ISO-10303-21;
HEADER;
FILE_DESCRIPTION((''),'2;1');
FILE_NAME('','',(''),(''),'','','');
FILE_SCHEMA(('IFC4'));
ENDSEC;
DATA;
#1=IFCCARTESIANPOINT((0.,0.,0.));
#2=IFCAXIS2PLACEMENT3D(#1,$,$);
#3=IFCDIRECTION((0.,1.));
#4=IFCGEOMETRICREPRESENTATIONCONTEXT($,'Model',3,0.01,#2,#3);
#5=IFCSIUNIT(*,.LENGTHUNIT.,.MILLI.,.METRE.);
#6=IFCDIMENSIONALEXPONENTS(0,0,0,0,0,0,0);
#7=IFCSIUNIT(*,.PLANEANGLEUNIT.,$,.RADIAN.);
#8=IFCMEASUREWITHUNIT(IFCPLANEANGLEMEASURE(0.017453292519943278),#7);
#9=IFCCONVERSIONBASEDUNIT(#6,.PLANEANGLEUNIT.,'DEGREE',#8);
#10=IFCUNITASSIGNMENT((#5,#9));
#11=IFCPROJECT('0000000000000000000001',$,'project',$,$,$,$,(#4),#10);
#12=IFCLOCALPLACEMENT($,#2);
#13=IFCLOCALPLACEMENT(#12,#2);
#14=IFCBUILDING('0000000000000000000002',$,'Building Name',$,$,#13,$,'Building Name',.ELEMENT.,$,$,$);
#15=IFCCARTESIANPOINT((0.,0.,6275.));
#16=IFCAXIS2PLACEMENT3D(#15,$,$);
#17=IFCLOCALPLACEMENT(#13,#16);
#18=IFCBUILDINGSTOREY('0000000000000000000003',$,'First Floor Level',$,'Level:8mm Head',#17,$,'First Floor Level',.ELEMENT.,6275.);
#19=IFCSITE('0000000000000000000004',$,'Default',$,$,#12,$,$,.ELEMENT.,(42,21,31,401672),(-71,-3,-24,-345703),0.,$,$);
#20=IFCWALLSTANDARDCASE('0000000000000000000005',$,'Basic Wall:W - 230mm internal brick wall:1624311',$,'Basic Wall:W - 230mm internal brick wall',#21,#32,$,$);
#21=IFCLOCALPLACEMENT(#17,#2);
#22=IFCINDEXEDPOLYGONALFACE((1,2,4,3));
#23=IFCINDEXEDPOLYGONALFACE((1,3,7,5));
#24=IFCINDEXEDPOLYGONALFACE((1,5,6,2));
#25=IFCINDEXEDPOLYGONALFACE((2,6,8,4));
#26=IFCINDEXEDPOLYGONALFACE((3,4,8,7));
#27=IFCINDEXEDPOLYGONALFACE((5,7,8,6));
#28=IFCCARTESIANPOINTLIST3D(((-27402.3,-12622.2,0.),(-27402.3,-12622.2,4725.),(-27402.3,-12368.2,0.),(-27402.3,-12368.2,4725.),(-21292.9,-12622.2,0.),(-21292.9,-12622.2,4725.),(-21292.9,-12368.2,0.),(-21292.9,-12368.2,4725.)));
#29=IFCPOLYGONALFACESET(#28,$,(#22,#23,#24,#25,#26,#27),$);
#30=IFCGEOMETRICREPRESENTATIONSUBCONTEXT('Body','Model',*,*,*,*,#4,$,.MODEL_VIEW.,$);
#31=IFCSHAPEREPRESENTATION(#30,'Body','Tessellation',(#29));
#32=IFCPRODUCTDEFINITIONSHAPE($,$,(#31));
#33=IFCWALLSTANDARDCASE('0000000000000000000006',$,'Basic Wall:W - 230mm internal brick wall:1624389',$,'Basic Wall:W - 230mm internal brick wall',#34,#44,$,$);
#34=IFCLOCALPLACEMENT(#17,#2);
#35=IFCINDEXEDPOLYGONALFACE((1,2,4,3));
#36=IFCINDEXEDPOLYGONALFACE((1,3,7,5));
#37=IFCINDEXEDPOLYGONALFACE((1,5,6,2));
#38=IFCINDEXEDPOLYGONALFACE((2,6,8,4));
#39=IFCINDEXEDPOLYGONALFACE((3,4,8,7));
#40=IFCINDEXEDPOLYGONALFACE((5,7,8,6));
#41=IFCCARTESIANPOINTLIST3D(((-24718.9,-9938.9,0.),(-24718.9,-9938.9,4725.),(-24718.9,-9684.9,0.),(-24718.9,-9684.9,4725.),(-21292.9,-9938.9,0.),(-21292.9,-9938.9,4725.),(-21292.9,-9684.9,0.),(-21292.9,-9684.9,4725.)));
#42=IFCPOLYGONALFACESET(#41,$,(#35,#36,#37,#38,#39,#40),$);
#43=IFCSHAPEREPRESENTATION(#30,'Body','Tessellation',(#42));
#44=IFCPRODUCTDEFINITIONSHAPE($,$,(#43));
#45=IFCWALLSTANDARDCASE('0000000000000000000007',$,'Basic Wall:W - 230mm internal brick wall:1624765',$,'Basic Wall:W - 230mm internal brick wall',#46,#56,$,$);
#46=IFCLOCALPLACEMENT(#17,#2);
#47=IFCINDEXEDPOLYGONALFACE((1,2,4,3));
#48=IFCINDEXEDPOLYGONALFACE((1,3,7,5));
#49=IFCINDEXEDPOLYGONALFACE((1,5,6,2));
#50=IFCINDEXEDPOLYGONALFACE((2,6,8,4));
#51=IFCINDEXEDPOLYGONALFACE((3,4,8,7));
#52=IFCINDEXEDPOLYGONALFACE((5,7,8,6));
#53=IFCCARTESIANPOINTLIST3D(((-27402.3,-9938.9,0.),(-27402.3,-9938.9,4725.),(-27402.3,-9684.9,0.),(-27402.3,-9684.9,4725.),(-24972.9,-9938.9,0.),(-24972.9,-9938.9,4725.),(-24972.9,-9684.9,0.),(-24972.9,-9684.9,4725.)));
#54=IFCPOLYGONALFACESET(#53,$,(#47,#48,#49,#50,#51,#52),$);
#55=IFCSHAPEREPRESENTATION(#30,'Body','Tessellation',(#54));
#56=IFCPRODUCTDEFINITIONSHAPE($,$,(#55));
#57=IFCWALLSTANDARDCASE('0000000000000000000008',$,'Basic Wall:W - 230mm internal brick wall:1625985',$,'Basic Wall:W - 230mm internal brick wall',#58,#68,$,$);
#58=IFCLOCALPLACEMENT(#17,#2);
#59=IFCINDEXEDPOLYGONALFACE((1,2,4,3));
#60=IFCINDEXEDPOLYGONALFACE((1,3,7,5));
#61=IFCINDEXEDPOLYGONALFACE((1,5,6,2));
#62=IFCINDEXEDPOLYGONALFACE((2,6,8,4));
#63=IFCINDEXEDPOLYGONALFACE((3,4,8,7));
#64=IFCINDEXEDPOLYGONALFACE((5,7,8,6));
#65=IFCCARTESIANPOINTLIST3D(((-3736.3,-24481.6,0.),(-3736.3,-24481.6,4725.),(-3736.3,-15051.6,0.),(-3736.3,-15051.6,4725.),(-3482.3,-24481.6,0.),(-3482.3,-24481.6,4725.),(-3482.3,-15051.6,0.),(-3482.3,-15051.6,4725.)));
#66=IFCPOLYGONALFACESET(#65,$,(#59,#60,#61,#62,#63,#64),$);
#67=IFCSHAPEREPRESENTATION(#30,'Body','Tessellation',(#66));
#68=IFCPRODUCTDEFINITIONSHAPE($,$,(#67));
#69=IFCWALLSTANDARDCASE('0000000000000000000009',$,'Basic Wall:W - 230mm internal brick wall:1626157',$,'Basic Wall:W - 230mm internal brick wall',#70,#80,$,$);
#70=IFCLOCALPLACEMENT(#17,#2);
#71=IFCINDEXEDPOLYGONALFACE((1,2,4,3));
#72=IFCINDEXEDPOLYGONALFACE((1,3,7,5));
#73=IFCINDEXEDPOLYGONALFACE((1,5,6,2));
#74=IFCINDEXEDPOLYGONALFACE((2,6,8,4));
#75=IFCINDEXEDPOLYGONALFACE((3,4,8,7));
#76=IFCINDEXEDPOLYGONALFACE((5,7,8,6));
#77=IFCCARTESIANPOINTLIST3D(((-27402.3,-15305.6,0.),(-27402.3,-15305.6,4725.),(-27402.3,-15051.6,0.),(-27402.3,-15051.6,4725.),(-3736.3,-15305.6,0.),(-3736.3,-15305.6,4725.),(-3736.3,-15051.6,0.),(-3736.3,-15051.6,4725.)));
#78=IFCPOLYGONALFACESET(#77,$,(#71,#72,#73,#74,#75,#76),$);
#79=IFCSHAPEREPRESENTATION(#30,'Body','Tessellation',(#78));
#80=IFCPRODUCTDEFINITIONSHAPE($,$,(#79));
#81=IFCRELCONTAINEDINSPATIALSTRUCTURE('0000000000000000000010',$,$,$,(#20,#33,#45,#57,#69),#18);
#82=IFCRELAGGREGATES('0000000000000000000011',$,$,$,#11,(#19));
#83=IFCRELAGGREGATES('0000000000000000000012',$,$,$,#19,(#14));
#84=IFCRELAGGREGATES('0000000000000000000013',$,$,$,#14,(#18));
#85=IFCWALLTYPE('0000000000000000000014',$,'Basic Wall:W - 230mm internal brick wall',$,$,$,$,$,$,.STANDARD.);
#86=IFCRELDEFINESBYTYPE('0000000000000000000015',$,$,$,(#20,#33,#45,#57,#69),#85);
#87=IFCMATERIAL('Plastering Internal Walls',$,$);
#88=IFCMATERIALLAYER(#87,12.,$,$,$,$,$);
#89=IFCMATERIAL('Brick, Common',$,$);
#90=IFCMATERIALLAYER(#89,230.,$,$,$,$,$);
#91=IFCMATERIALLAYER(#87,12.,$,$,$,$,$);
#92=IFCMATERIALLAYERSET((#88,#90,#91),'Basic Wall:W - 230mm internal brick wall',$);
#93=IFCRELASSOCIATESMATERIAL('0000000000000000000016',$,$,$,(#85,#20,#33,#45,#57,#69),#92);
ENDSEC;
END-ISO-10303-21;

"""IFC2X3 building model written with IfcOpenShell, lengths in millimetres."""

from ifc_helpers import new_model, entity, si_unit, converted_unit, direction, frame, frame_2d, origin, place, context, subcontext, project, spatial, rectangle, extrude, material, layer, layer_set, layer_usage, type_object, element, save


model = new_model("IFC2X3")

# Units and contexts
model_context = context("Model", 3, precision=0.01, world=origin(), true_north=direction((0.0, 1.0)))
body_context = subcontext(model_context, "Body", "Model", "MODEL_VIEW")
ifc_project = project(units=[si_unit("LENGTHUNIT", "METRE", prefix="MILLI"), converted_unit("PLANEANGLEUNIT", "DEGREE", entity("IfcPlaneAngleMeasure", 0.017453292519943278), si_unit("PLANEANGLEUNIT", "RADIAN"), dimensions=[0, 0, 0, 0, 0, 0, 0])], contexts=[model_context])

# Site, building, storey
site_placement = place(None, origin())
site = spatial("IfcSite", under=ifc_project, at=site_placement, Name="Default", CompositionType="ELEMENT", RefLatitude=(42, 21, 31, 401672), RefLongitude=(-71, -3, -24, -345703), RefElevation=0.0)
building_placement = place(site_placement, origin())
building = spatial("IfcBuilding", under=site, at=building_placement, Name="Building Name", LongName="Building Name", CompositionType="ELEMENT")
storey_placement = place(building_placement, frame((0.0, 0.0, 6275.0)))
storey = spatial("IfcBuildingStorey", under=building, at=storey_placement, Name="First Floor Level", ObjectType="Level:8mm Head", LongName="First Floor Level", CompositionType="ELEMENT", Elevation=6275.0)

# Walls
ifc_material_1 = material(Name="Brick, Common")
ifc_material_2 = material(Name="Plastering Internal Walls")
ifc_layer_1 = layer(ifc_material_2, 12.0)
ifc_layer_2 = layer(ifc_material_1, 230.0)
ifc_layer_3 = layer(ifc_material_2, 12.0)
ifc_layer_set_1 = layer_set([ifc_layer_1, ifc_layer_2, ifc_layer_3], Name="Basic Wall:W - 230mm internal brick wall")
wall_type_1 = type_object("IfcWallType", Name="Basic Wall:W - 230mm internal brick wall", PredefinedType="STANDARD", material=ifc_layer_set_1)
ifc_layer_usage_1 = layer_usage(ifc_layer_set_1, "AXIS2", "NEGATIVE", 127.0)
wall_1_placement = place(storey_placement, frame((-21292.9, -12495.2, 0.0), z_axis=(0.0, 0.0, 1.0), x_axis=(-1.0, 0.0, 0.0)))
element("IfcWallStandardCase", 1, at=wall_1_placement, inside=storey, type_object=wall_type_1, material=ifc_layer_usage_1, Name="Basic Wall:W - 230mm internal brick wall:1624311", ObjectType="Basic Wall:W - 230mm internal brick wall", context=body_context, shape_type="SweptSolid", body=[
    extrude(rectangle(XDim=6109.3, YDim=254.0, at=frame_2d((3054.7, 0.0), x_axis=(-1.0, 0.0))), origin(), (0.0, 0.0, 1.0), 4725.0),
])
ifc_layer_usage_2 = layer_usage(ifc_layer_set_1, "AXIS2", "NEGATIVE", 127.0)
wall_2_placement = place(storey_placement, frame((-21292.9, -9811.9, 0.0), z_axis=(0.0, 0.0, 1.0), x_axis=(-1.0, 0.0, 0.0)))
element("IfcWallStandardCase", 2, at=wall_2_placement, inside=storey, type_object=wall_type_1, material=ifc_layer_usage_2, Name="Basic Wall:W - 230mm internal brick wall:1624389", ObjectType="Basic Wall:W - 230mm internal brick wall", context=body_context, shape_type="SweptSolid", body=[
    extrude(rectangle(XDim=3426.0, YDim=254.0, at=frame_2d((1713.0, 0.0), x_axis=(-1.0, 0.0))), origin(), (0.0, 0.0, 1.0), 4725.0),
])
ifc_layer_usage_3 = layer_usage(ifc_layer_set_1, "AXIS2", "NEGATIVE", 127.0)
wall_3_placement = place(storey_placement, frame((-24972.9, -9811.9, 0.0), z_axis=(0.0, 0.0, 1.0), x_axis=(-1.0, 0.0, 0.0)))
element("IfcWallStandardCase", 3, at=wall_3_placement, inside=storey, type_object=wall_type_1, material=ifc_layer_usage_3, Name="Basic Wall:W - 230mm internal brick wall:1624765", ObjectType="Basic Wall:W - 230mm internal brick wall", context=body_context, shape_type="SweptSolid", body=[
    extrude(rectangle(XDim=2429.3, YDim=254.0, at=frame_2d((1214.7, 0.0), x_axis=(-1.0, 0.0))), origin(), (0.0, 0.0, 1.0), 4725.0),
])
ifc_layer_usage_4 = layer_usage(ifc_layer_set_1, "AXIS2", "NEGATIVE", 127.0)
wall_4_placement = place(storey_placement, frame((-3609.3, -15051.6, 0.0), z_axis=(0.0, 0.0, 1.0), x_axis=(0.0, -1.0, 0.0)))
element("IfcWallStandardCase", 4, at=wall_4_placement, inside=storey, type_object=wall_type_1, material=ifc_layer_usage_4, Name="Basic Wall:W - 230mm internal brick wall:1625985", ObjectType="Basic Wall:W - 230mm internal brick wall", context=body_context, shape_type="SweptSolid", body=[
    extrude(rectangle(XDim=9430.0, YDim=254.0, at=frame_2d((4715.0, 0.0), x_axis=(-1.0, 0.0))), origin(), (0.0, 0.0, 1.0), 4725.0),
])
ifc_layer_usage_5 = layer_usage(ifc_layer_set_1, "AXIS2", "NEGATIVE", 127.0)
wall_5_placement = place(storey_placement, frame((-3736.3, -15178.6, 0.0), z_axis=(0.0, 0.0, 1.0), x_axis=(-1.0, 0.0, 0.0)))
element("IfcWallStandardCase", 5, at=wall_5_placement, inside=storey, type_object=wall_type_1, material=ifc_layer_usage_5, Name="Basic Wall:W - 230mm internal brick wall:1626157", ObjectType="Basic Wall:W - 230mm internal brick wall", context=body_context, shape_type="SweptSolid", body=[
    extrude(rectangle(XDim=23666.0, YDim=254.0, at=frame_2d((11833.0, 0.0), x_axis=(-1.0, 0.0))), origin(), (0.0, 0.0, 1.0), 4725.0),
])

save(model, "model.ifc")
